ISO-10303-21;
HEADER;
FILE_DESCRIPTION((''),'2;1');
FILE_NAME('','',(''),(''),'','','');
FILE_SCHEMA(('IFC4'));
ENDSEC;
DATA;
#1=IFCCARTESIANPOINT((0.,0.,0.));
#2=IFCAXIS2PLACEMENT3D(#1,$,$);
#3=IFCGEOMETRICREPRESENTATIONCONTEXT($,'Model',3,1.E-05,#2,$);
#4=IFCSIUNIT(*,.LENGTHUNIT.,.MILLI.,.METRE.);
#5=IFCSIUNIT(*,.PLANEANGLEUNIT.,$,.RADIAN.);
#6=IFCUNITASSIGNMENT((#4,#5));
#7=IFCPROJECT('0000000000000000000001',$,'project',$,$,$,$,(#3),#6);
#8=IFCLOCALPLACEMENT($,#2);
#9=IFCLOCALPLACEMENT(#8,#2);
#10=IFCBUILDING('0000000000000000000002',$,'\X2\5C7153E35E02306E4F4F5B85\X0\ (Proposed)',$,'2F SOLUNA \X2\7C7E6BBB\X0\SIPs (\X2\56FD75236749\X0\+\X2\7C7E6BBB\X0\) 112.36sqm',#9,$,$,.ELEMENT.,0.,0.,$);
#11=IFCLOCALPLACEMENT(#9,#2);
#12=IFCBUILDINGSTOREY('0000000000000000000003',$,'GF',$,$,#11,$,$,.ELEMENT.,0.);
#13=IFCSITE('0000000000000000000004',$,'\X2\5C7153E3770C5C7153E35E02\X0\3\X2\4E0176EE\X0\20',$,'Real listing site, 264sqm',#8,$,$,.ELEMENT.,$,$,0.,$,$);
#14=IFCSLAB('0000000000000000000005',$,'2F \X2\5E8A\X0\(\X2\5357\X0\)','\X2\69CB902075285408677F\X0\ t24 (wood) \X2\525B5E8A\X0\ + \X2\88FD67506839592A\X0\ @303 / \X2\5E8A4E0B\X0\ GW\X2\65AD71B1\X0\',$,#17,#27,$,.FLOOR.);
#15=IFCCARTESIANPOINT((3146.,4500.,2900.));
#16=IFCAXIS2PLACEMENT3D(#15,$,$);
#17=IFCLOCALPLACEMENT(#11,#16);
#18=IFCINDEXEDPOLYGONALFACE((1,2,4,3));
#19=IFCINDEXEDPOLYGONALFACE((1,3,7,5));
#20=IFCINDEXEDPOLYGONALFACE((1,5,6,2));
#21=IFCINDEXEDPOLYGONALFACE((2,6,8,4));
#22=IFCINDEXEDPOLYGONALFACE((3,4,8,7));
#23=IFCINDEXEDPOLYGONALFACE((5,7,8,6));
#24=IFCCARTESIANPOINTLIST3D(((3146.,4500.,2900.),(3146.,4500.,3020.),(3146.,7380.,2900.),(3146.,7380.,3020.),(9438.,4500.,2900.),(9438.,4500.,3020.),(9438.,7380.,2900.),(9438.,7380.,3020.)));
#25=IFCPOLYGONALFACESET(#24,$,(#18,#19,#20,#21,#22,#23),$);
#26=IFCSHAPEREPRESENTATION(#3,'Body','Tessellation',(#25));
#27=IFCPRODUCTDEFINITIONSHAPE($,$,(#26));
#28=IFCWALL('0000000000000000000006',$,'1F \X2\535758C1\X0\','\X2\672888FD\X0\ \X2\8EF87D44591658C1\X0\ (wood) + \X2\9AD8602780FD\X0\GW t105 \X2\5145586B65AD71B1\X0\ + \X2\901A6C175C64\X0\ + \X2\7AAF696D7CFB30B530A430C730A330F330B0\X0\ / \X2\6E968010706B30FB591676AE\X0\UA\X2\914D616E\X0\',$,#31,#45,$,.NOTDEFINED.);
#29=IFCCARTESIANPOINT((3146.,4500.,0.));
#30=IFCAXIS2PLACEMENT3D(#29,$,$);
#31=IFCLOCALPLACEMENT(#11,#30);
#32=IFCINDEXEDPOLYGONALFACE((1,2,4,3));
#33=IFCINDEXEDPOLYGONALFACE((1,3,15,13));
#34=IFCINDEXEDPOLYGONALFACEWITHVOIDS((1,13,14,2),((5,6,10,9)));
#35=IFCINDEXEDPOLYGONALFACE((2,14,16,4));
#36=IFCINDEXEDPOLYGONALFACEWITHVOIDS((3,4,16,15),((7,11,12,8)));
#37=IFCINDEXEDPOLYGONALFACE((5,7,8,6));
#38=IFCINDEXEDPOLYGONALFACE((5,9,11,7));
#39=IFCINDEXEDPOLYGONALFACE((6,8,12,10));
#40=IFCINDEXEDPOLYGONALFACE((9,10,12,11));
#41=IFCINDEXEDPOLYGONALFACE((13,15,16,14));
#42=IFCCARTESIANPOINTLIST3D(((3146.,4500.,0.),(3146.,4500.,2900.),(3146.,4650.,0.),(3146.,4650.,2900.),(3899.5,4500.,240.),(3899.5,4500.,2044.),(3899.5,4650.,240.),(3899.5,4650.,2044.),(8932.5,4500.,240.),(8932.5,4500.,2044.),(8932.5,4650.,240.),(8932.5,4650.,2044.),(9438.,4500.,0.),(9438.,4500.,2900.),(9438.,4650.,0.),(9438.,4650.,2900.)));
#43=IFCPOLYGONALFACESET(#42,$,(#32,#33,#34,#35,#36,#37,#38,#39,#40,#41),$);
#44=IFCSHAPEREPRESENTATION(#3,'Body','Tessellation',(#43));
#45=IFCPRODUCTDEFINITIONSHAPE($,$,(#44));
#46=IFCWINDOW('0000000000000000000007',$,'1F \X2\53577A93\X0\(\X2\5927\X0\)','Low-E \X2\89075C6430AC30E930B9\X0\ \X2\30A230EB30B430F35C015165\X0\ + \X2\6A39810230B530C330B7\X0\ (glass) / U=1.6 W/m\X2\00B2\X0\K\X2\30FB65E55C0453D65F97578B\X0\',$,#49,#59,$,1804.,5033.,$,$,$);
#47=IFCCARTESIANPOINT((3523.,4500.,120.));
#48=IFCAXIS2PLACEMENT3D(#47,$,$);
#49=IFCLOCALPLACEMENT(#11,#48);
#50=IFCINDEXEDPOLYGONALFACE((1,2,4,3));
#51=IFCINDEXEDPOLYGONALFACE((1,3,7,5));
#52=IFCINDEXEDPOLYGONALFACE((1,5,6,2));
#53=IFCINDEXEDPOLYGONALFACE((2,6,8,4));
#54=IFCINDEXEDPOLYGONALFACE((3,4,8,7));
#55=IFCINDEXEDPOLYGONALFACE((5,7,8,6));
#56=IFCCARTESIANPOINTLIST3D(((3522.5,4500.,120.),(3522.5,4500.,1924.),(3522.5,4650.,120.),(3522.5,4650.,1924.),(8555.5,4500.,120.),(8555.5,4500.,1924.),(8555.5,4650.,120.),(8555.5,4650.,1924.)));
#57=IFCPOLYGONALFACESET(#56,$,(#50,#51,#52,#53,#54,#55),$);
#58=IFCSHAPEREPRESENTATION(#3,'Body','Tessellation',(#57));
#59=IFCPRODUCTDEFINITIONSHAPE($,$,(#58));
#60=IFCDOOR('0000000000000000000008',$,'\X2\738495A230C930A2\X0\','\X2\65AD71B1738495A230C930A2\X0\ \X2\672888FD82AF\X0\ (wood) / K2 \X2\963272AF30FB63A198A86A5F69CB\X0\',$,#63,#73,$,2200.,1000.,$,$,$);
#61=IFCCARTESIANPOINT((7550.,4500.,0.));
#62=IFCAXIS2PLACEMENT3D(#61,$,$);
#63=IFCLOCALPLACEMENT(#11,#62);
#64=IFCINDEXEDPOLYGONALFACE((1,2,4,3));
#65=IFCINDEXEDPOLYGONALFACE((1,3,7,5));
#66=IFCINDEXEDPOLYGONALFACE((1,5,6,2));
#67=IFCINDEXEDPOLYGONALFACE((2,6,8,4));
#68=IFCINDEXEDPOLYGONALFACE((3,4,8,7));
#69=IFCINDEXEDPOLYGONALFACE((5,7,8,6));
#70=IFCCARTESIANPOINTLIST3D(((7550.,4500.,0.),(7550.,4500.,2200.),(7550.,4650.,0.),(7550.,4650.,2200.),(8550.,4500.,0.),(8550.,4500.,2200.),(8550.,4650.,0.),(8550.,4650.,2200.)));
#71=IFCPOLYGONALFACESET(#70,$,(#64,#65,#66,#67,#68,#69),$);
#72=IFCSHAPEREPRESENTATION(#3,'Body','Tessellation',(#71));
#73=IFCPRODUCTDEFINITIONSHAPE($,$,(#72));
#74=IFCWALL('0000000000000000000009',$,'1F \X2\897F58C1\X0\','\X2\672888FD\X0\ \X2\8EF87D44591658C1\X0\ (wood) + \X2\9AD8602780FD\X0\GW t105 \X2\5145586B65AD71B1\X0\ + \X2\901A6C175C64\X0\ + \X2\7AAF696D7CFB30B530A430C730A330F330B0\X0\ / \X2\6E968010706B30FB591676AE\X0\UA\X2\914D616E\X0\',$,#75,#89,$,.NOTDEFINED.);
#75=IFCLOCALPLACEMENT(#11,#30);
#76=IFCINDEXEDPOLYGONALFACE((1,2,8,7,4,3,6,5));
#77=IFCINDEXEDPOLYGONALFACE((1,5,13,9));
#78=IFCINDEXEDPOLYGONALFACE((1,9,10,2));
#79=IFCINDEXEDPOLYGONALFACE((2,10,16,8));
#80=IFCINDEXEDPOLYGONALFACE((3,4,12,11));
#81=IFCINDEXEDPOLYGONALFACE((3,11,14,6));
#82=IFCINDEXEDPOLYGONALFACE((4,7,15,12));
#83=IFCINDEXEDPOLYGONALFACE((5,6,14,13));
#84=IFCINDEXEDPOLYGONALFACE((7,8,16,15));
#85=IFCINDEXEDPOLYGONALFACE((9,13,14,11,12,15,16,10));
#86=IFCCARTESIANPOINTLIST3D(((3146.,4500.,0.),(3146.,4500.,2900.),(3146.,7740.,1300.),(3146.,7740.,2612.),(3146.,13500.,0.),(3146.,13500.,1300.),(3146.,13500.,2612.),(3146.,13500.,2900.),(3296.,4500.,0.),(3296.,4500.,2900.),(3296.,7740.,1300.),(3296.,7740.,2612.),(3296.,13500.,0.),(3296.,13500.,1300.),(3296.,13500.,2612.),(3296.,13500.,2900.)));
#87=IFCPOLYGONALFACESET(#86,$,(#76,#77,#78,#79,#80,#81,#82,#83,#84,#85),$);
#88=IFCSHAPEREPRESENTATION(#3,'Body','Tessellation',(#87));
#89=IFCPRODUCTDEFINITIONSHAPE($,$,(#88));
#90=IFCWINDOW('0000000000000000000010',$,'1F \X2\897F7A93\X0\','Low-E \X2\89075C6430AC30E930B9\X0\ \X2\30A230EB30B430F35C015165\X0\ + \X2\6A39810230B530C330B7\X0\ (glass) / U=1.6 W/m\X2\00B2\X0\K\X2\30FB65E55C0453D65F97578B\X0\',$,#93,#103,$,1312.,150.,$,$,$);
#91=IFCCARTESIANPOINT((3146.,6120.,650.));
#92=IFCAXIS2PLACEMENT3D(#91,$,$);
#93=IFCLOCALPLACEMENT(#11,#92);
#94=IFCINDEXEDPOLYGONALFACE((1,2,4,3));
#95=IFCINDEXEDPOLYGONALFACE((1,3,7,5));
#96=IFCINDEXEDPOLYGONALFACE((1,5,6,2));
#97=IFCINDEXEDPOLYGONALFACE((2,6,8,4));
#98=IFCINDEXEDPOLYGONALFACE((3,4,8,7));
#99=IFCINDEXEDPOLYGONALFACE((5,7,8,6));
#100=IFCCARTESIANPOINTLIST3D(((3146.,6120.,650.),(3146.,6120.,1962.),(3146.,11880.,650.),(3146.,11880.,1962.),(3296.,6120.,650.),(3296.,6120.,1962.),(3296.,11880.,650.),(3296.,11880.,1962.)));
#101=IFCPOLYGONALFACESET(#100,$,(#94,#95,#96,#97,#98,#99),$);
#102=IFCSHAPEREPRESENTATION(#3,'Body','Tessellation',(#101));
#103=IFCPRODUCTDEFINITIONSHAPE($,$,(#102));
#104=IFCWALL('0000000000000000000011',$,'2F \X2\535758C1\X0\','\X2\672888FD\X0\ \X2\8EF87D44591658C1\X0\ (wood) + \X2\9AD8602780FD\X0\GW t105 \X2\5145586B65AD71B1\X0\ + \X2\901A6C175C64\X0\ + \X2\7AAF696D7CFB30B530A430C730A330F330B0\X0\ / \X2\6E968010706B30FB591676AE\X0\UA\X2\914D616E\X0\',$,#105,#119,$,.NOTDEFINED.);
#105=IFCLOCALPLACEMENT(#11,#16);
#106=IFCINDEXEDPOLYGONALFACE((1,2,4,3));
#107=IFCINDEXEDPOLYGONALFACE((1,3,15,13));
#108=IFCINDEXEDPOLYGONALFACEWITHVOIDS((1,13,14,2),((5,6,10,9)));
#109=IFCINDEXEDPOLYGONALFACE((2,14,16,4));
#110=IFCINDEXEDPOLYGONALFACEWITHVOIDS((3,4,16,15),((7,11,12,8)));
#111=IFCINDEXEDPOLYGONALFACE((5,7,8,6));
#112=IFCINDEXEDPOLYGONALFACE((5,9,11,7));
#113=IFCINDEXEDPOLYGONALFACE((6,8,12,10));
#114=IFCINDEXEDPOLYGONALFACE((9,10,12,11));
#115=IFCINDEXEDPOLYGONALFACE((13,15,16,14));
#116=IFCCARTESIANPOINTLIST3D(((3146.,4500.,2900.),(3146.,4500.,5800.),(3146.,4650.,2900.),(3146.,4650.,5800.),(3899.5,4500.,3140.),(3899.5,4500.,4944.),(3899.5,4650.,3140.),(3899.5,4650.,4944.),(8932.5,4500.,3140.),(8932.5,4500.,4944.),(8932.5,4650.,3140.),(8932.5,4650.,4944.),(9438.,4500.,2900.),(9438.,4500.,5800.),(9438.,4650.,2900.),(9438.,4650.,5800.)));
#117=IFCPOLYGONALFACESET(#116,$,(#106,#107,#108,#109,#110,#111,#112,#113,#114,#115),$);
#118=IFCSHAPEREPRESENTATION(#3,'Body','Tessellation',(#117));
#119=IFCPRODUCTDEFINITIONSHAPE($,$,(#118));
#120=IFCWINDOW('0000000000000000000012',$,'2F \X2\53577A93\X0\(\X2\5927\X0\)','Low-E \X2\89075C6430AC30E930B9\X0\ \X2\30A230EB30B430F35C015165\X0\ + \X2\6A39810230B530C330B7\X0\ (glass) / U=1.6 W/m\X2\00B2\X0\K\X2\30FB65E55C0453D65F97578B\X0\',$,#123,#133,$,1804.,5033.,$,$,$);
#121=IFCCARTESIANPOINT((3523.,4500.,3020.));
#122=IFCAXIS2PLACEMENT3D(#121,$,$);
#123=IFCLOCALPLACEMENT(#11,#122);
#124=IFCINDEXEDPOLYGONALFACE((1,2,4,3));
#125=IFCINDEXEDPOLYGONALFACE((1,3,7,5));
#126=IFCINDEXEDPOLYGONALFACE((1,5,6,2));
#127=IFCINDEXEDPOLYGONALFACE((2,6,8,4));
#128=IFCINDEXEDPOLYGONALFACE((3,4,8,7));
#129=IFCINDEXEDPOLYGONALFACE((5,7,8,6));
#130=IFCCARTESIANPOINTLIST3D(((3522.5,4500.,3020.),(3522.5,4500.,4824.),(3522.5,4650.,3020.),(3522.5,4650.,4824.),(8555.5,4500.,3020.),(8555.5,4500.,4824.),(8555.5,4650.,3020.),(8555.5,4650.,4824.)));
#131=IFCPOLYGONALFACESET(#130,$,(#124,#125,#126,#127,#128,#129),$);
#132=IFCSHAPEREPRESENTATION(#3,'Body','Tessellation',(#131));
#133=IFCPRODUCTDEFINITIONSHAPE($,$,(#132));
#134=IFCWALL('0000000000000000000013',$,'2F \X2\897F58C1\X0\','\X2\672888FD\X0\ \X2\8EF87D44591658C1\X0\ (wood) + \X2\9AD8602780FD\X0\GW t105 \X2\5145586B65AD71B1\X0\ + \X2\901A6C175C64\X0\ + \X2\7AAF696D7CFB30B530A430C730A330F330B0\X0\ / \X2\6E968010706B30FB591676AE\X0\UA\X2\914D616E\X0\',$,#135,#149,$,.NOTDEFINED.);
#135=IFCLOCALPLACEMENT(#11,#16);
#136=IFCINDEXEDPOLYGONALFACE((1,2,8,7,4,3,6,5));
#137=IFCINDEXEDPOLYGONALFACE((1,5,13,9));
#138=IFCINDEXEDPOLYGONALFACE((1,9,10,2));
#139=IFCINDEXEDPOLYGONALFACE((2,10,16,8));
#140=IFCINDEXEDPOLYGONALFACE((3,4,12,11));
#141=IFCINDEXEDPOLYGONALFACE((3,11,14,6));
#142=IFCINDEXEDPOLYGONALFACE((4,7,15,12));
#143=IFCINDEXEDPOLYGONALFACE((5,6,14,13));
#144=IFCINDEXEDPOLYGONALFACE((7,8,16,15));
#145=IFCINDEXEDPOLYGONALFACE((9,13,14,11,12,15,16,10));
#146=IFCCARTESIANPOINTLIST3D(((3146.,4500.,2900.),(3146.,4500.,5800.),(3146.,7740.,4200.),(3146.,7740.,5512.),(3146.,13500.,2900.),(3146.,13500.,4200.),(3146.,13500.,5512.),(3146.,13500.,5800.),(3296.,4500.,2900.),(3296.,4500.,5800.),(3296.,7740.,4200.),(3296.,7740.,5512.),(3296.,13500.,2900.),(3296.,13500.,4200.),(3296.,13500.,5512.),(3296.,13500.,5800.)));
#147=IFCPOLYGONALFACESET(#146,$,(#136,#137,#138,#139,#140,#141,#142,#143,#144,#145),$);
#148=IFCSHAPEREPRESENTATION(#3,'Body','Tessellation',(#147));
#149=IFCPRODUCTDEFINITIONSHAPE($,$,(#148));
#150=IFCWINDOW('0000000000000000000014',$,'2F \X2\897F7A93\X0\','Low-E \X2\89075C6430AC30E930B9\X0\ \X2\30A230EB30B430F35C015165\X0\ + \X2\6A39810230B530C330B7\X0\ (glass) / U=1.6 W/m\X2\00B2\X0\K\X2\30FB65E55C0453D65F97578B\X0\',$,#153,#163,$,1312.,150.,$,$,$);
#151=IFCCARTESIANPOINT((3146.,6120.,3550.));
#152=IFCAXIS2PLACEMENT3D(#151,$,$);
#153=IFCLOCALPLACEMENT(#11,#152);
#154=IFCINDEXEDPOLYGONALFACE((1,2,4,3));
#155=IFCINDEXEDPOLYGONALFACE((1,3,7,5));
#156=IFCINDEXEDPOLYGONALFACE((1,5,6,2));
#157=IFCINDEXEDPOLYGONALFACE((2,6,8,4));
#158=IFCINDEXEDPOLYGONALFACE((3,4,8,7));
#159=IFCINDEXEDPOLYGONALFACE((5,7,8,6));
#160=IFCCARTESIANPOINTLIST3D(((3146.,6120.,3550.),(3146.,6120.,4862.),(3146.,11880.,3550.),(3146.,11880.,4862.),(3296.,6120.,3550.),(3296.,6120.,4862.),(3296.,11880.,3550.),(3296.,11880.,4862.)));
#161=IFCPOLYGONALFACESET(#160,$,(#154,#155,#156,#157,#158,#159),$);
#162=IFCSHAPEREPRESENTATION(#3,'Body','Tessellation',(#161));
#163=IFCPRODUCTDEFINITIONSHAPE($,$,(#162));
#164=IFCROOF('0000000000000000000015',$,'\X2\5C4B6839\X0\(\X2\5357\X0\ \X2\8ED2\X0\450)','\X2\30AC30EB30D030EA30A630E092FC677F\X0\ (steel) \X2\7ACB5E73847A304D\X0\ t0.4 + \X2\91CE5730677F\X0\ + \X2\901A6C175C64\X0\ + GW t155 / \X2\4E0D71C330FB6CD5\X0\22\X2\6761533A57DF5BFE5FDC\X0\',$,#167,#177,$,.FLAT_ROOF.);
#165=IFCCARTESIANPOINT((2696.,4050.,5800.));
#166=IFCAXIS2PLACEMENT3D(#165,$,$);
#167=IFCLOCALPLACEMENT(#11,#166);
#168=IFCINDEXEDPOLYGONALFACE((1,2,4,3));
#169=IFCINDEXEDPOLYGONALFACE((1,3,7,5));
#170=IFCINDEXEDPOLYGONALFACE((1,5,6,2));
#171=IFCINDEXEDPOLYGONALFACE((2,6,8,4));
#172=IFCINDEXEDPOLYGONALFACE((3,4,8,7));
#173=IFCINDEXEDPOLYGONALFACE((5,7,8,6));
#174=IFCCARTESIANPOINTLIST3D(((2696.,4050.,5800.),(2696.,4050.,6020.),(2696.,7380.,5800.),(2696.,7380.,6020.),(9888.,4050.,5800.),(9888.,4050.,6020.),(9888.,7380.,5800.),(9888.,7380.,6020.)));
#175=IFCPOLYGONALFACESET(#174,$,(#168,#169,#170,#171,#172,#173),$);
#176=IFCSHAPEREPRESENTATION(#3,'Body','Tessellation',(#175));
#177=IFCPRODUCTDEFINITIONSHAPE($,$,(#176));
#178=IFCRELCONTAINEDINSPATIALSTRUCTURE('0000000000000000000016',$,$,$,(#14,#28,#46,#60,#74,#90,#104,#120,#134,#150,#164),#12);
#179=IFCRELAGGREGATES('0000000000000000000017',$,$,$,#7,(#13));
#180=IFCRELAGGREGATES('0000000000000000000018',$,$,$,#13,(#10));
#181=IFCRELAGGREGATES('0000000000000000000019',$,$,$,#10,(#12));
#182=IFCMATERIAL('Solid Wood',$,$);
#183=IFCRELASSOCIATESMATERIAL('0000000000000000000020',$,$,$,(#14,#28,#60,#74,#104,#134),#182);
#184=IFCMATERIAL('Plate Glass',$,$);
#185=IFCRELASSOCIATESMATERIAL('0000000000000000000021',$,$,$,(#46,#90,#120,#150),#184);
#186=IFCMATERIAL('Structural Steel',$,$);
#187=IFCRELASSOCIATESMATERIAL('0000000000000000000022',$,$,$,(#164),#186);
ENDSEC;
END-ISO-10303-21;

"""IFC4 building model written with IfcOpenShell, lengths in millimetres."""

from ifc_helpers import new_model, si_unit, frame, frame_2d, origin, place, context, project, spatial, rectangle, extrude, material, element, fill, save


model = new_model("IFC4")

# Units and contexts
model_context = context("Model", 3, precision=1e-05, world=origin())
ifc_project = project(units=[si_unit("LENGTHUNIT", "METRE", prefix="MILLI"), si_unit("PLANEANGLEUNIT", "RADIAN")], contexts=[model_context])

# Site, building, storey
site_placement = place(None, origin())
site = spatial("IfcSite", under=ifc_project, at=site_placement, Name="山口県山口市3丁目20", ObjectType="Real listing site, 264sqm", CompositionType="ELEMENT", RefElevation=0.0)
building_placement = place(site_placement, origin())
building = spatial("IfcBuilding", under=site, at=building_placement, Name="山口市の住宅 (Proposed)", ObjectType="2F SOLUNA 籾殻SIPs (国産杉+籾殻) 112.36sqm", CompositionType="ELEMENT", ElevationOfRefHeight=0.0, ElevationOfTerrain=0.0)
storey_placement = place(building_placement, origin())
storey = spatial("IfcBuildingStorey", under=building, at=storey_placement, Name="GF", CompositionType="ELEMENT", Elevation=0.0)

# Slab
ifc_material_1 = material(Name="Solid Wood")
slab_1_placement = place(storey_placement, frame((3146.0, 4500.0, 2900.0)))
element("IfcSlab", 1, at=slab_1_placement, inside=storey, material=ifc_material_1, Name="2F 床(南)", Description="構造用合板 t24 (wood) 剛床 + 製材根太 @303 / 床下 GW断熱", PredefinedType="FLOOR", context=model_context, shape_type="SweptSolid", body=[
    extrude(rectangle(XDim=6292.0, YDim=2880.0, at=frame_2d((3146.0, 1440.0))), frame((3146.0, 4500.0, 2900.0)), (0.0, 0.0, 1.0), 120.0),
])

# Wall, openings, window, door
wall_1_placement = place(storey_placement, frame((3146.0, 4500.0, 0.0)))
wall_1 = element("IfcWall", 2, at=wall_1_placement, inside=storey, material=ifc_material_1, Name="1F 南壁", Description="木製 軸組外壁 (wood) + 高性能GW t105 充填断熱 + 通気層 + 窯業系サイディング / 準耐火・外皮UA配慮", PredefinedType="NOTDEFINED", context=model_context, shape_type="SweptSolid", body=[
    extrude(rectangle(XDim=6292.0, YDim=150.0, at=frame_2d((3146.0, 75.0))), frame((3146.0, 4500.0, 0.0)), (0.0, 0.0, 1.0), 2900.0),
])
opening_1_placement = place(storey_placement, frame((3523.0, 4500.0, 120.0)))
opening_1 = element("IfcOpeningElement", 3, at=opening_1_placement, cuts=wall_1, PredefinedType="NOTDEFINED", context=model_context, shape_type="SweptSolid", body=[
    extrude(rectangle(XDim=5033.0, YDim=150.0, at=frame_2d((2516.0, 75.0))), frame((3523.0, 4500.0, 120.0)), (0.0, 0.0, 1.0), 1804.0),
])
opening_2_placement = place(storey_placement, frame((7550.0, 4500.0, 0.0)))
opening_2 = element("IfcOpeningElement", 4, at=opening_2_placement, cuts=wall_1, PredefinedType="NOTDEFINED", context=model_context, shape_type="SweptSolid", body=[
    extrude(rectangle(XDim=1000.0, YDim=150.0, at=frame_2d((500.0, 75.0))), frame((7550.0, 4500.0, 0.0)), (0.0, 0.0, 1.0), 2200.0),
])
ifc_material_2 = material(Name="Plate Glass")
window_1_placement = place(storey_placement, frame((3523.0, 4500.0, 120.0)))
window_1 = element("IfcWindow", 5, at=window_1_placement, inside=storey, material=ifc_material_2, Name="1F 南窓(大)", Description="Low-E 複層ガラス アルゴン封入 + 樹脂サッシ (glass) / U=1.6 W/m²K・日射取得型", OverallHeight=1804.0, OverallWidth=5033.0, context=model_context, shape_type="SweptSolid", body=[
    extrude(rectangle(XDim=5033.0, YDim=150.0, at=frame_2d((2516.0, 75.0))), frame((3523.0, 4500.0, 120.0)), (0.0, 0.0, 1.0), 1804.0),
])
fill(opening_1, window_1)
door_placement = place(storey_placement, frame((7550.0, 4500.0, 0.0)))
door = element("IfcDoor", 6, at=door_placement, inside=storey, material=ifc_material_1, Name="玄関ドア", Description="断熱玄関ドア 木製芯 (wood) / K2 防犯・採風機構", OverallHeight=2200.0, OverallWidth=1000.0, context=model_context, shape_type="SweptSolid", body=[
    extrude(rectangle(XDim=1000.0, YDim=150.0, at=frame_2d((500.0, 75.0))), frame((7550.0, 4500.0, 0.0)), (0.0, 0.0, 1.0), 2200.0),
])
fill(opening_2, door)

# Walls, openings, windows
wall_2_placement = place(storey_placement, frame((3146.0, 4500.0, 0.0)))
wall_2 = element("IfcWall", 7, at=wall_2_placement, inside=storey, material=ifc_material_1, Name="1F 西壁", Description="木製 軸組外壁 (wood) + 高性能GW t105 充填断熱 + 通気層 + 窯業系サイディング / 準耐火・外皮UA配慮", PredefinedType="NOTDEFINED", context=model_context, shape_type="SweptSolid", body=[
    extrude(rectangle(XDim=150.0, YDim=9000.0, at=frame_2d((75.0, 4500.0))), frame((3146.0, 4500.0, 0.0)), (0.0, 0.0, 1.0), 2900.0),
])
opening_3_placement = place(storey_placement, frame((3146.0, 6120.0, 650.0)))
opening_3 = element("IfcOpeningElement", 8, at=opening_3_placement, cuts=wall_2, PredefinedType="NOTDEFINED", context=model_context, shape_type="SweptSolid", body=[
    extrude(rectangle(XDim=150.0, YDim=5760.0, at=frame_2d((75.0, 2880.0))), frame((3146.0, 6120.0, 650.0)), (0.0, 0.0, 1.0), 1312.0),
])
window_2_placement = place(storey_placement, frame((3146.0, 6120.0, 650.0)))
window_2 = element("IfcWindow", 9, at=window_2_placement, inside=storey, material=ifc_material_2, Name="1F 西窓", Description="Low-E 複層ガラス アルゴン封入 + 樹脂サッシ (glass) / U=1.6 W/m²K・日射取得型", OverallHeight=1312.0, OverallWidth=150.0, context=model_context, shape_type="SweptSolid", body=[
    extrude(rectangle(XDim=150.0, YDim=5760.0, at=frame_2d((75.0, 2880.0))), frame((3146.0, 6120.0, 650.0)), (0.0, 0.0, 1.0), 1312.0),
])
fill(opening_3, window_2)
wall_3_placement = place(storey_placement, frame((3146.0, 4500.0, 2900.0)))
wall_3 = element("IfcWall", 10, at=wall_3_placement, inside=storey, material=ifc_material_1, Name="2F 南壁", Description="木製 軸組外壁 (wood) + 高性能GW t105 充填断熱 + 通気層 + 窯業系サイディング / 準耐火・外皮UA配慮", PredefinedType="NOTDEFINED", context=model_context, shape_type="SweptSolid", body=[
    extrude(rectangle(XDim=6292.0, YDim=150.0, at=frame_2d((3146.0, 75.0))), frame((3146.0, 4500.0, 2900.0)), (0.0, 0.0, 1.0), 2900.0),
])
opening_4_placement = place(storey_placement, frame((3523.0, 4500.0, 3020.0)))
opening_4 = element("IfcOpeningElement", 11, at=opening_4_placement, cuts=wall_3, PredefinedType="NOTDEFINED", context=model_context, shape_type="SweptSolid", body=[
    extrude(rectangle(XDim=5033.0, YDim=150.0, at=frame_2d((2516.0, 75.0))), frame((3523.0, 4500.0, 3020.0)), (0.0, 0.0, 1.0), 1804.0),
])
window_3_placement = place(storey_placement, frame((3523.0, 4500.0, 3020.0)))
window_3 = element("IfcWindow", 12, at=window_3_placement, inside=storey, material=ifc_material_2, Name="2F 南窓(大)", Description="Low-E 複層ガラス アルゴン封入 + 樹脂サッシ (glass) / U=1.6 W/m²K・日射取得型", OverallHeight=1804.0, OverallWidth=5033.0, context=model_context, shape_type="SweptSolid", body=[
    extrude(rectangle(XDim=5033.0, YDim=150.0, at=frame_2d((2516.0, 75.0))), frame((3523.0, 4500.0, 3020.0)), (0.0, 0.0, 1.0), 1804.0),
])
fill(opening_4, window_3)
wall_4_placement = place(storey_placement, frame((3146.0, 4500.0, 2900.0)))
wall_4 = element("IfcWall", 13, at=wall_4_placement, inside=storey, material=ifc_material_1, Name="2F 西壁", Description="木製 軸組外壁 (wood) + 高性能GW t105 充填断熱 + 通気層 + 窯業系サイディング / 準耐火・外皮UA配慮", PredefinedType="NOTDEFINED", context=model_context, shape_type="SweptSolid", body=[
    extrude(rectangle(XDim=150.0, YDim=9000.0, at=frame_2d((75.0, 4500.0))), frame((3146.0, 4500.0, 2900.0)), (0.0, 0.0, 1.0), 2900.0),
])
opening_5_placement = place(storey_placement, frame((3146.0, 6120.0, 3550.0)))
opening_5 = element("IfcOpeningElement", 14, at=opening_5_placement, cuts=wall_4, PredefinedType="NOTDEFINED", context=model_context, shape_type="SweptSolid", body=[
    extrude(rectangle(XDim=150.0, YDim=5760.0, at=frame_2d((75.0, 2880.0))), frame((3146.0, 6120.0, 3550.0)), (0.0, 0.0, 1.0), 1312.0),
])
window_4_placement = place(storey_placement, frame((3146.0, 6120.0, 3550.0)))
window_4 = element("IfcWindow", 15, at=window_4_placement, inside=storey, material=ifc_material_2, Name="2F 西窓", Description="Low-E 複層ガラス アルゴン封入 + 樹脂サッシ (glass) / U=1.6 W/m²K・日射取得型", OverallHeight=1312.0, OverallWidth=150.0, context=model_context, shape_type="SweptSolid", body=[
    extrude(rectangle(XDim=150.0, YDim=5760.0, at=frame_2d((75.0, 2880.0))), frame((3146.0, 6120.0, 3550.0)), (0.0, 0.0, 1.0), 1312.0),
])
fill(opening_5, window_4)

# Roof
ifc_material_3 = material(Name="Structural Steel")
roof_1_placement = place(storey_placement, frame((2696.0, 4050.0, 5800.0)))
element("IfcRoof", 16, at=roof_1_placement, inside=storey, material=ifc_material_3, Name="屋根(南 軒450)", Description="ガルバリウム鋼板 (steel) 立平葺き t0.4 + 野地板 + 通気層 + GW t155 / 不燃・法22条区域対応", PredefinedType="FLAT_ROOF", context=model_context, shape_type="SweptSolid", body=[
    extrude(rectangle(XDim=7192.0, YDim=3330.0, at=frame_2d((3596.0, 1665.0))), frame((2696.0, 4050.0, 5800.0)), (0.0, 0.0, 1.0), 220.0),
])

save(model, "model.ifc")
